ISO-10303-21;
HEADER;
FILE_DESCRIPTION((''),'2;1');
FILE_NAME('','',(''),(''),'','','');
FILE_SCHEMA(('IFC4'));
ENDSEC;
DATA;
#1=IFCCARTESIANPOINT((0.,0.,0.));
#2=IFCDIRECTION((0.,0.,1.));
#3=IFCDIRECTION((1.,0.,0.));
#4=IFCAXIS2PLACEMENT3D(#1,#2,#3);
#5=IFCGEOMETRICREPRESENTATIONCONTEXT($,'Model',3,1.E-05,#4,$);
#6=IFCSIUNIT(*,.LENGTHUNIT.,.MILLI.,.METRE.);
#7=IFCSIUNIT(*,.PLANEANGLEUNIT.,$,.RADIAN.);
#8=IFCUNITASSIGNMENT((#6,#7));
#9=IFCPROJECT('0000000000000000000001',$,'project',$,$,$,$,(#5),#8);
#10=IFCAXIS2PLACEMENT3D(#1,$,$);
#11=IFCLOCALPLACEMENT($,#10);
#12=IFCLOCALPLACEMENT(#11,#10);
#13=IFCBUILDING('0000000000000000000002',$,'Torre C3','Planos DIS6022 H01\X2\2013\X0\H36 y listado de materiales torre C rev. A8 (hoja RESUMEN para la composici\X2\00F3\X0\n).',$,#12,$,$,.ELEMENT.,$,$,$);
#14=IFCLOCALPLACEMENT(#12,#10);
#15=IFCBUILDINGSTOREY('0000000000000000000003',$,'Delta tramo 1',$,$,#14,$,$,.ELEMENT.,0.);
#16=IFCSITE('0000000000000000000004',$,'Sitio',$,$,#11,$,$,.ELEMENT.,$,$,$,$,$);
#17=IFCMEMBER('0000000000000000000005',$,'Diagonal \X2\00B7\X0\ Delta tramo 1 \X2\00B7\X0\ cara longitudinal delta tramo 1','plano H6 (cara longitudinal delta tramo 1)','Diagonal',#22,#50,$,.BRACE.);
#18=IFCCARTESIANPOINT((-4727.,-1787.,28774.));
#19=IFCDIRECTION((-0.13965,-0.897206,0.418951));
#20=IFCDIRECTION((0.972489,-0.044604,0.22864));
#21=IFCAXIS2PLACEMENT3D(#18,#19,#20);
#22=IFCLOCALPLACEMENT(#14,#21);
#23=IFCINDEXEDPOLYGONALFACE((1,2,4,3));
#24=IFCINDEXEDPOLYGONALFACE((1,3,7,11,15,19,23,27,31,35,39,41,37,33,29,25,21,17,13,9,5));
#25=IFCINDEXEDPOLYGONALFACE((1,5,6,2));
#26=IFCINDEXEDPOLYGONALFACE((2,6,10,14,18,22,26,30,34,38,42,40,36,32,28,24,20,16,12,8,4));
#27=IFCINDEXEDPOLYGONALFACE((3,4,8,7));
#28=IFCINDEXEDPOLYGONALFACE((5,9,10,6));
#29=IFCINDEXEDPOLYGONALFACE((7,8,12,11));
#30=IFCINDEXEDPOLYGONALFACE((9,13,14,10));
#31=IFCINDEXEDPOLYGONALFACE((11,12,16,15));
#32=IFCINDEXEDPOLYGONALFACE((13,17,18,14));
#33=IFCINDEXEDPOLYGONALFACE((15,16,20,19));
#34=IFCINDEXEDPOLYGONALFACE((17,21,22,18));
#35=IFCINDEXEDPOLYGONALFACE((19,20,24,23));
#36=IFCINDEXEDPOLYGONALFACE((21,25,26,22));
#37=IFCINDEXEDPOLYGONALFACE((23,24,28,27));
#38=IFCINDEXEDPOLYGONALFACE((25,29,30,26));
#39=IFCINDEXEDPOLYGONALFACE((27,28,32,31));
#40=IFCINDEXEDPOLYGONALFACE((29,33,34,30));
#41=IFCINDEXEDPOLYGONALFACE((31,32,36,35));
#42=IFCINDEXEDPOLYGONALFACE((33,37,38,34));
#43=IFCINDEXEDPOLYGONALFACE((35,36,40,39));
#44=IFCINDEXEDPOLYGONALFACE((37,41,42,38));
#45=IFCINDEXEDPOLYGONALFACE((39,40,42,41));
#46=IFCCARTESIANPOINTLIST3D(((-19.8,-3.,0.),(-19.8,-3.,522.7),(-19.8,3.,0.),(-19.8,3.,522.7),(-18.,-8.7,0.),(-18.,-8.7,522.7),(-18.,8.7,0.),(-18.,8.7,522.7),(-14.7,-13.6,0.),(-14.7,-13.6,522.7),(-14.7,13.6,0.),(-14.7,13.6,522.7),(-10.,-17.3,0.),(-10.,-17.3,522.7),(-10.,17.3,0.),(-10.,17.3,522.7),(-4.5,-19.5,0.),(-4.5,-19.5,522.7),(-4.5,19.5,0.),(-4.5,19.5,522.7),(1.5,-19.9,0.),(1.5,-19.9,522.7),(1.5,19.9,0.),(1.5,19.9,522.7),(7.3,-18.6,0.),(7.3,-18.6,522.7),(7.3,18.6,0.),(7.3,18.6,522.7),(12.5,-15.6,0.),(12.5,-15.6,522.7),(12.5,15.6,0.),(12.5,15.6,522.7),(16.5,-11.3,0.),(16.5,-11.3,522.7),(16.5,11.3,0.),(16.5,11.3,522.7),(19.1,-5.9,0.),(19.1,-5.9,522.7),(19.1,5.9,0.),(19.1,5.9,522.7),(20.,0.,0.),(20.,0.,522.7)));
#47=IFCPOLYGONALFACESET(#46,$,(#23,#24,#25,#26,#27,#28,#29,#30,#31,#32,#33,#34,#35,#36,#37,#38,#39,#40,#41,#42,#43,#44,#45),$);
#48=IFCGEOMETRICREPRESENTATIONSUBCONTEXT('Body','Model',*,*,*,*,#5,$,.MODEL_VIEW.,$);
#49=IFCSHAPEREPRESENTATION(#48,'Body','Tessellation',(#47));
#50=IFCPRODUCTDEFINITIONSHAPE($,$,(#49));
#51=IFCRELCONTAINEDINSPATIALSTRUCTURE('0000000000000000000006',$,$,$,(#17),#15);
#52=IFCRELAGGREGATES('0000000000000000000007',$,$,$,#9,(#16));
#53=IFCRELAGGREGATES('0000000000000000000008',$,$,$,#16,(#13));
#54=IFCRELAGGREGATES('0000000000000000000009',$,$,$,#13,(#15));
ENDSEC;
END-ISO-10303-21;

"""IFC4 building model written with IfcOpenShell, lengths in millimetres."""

from ifc_helpers import new_model, si_unit, frame, origin, origin_with_axes, place, context, subcontext, project, spatial, circle, extrude, element, save


model = new_model("IFC4")

# Units and contexts
model_context = context("Model", 3, precision=1e-05, world=origin_with_axes())
body_context = subcontext(model_context, "Body", "Model", "MODEL_VIEW")
ifc_project = project(units=[si_unit("LENGTHUNIT", "METRE", prefix="MILLI"), si_unit("PLANEANGLEUNIT", "RADIAN")], contexts=[model_context])

# Site, building, storey
site_placement = place(None, origin())
site = spatial("IfcSite", under=ifc_project, at=site_placement, Name="Sitio", CompositionType="ELEMENT")
building_placement = place(site_placement, origin())
building = spatial("IfcBuilding", under=site, at=building_placement, Name="Torre C3", Description="Planos DIS6022 H01–H36 y listado de materiales torre C rev. A8 (hoja RESUMEN para la composición).", CompositionType="ELEMENT")
storey_placement = place(building_placement, origin())
storey = spatial("IfcBuildingStorey", under=building, at=storey_placement, Name="Delta tramo 1", CompositionType="ELEMENT", Elevation=0.0)

# Member
member_1_placement = place(storey_placement, frame((-4727.0, -1787.0, 28774.0), z_axis=(-0.13965, -0.897206, 0.418951), x_axis=(0.972489, -0.044604, 0.22864)))
element("IfcMember", 1, at=member_1_placement, inside=storey, Name="Diagonal · Delta tramo 1 · cara longitudinal delta tramo 1", Description="plano H6 (cara longitudinal delta tramo 1)", ObjectType="Diagonal", PredefinedType="BRACE", context=body_context, shape_type="SweptSolid", body=[
    extrude(circle(Radius=20.0), None, (0.0, 0.0, 1.0), 522.7),
])

save(model, "model.ifc")
